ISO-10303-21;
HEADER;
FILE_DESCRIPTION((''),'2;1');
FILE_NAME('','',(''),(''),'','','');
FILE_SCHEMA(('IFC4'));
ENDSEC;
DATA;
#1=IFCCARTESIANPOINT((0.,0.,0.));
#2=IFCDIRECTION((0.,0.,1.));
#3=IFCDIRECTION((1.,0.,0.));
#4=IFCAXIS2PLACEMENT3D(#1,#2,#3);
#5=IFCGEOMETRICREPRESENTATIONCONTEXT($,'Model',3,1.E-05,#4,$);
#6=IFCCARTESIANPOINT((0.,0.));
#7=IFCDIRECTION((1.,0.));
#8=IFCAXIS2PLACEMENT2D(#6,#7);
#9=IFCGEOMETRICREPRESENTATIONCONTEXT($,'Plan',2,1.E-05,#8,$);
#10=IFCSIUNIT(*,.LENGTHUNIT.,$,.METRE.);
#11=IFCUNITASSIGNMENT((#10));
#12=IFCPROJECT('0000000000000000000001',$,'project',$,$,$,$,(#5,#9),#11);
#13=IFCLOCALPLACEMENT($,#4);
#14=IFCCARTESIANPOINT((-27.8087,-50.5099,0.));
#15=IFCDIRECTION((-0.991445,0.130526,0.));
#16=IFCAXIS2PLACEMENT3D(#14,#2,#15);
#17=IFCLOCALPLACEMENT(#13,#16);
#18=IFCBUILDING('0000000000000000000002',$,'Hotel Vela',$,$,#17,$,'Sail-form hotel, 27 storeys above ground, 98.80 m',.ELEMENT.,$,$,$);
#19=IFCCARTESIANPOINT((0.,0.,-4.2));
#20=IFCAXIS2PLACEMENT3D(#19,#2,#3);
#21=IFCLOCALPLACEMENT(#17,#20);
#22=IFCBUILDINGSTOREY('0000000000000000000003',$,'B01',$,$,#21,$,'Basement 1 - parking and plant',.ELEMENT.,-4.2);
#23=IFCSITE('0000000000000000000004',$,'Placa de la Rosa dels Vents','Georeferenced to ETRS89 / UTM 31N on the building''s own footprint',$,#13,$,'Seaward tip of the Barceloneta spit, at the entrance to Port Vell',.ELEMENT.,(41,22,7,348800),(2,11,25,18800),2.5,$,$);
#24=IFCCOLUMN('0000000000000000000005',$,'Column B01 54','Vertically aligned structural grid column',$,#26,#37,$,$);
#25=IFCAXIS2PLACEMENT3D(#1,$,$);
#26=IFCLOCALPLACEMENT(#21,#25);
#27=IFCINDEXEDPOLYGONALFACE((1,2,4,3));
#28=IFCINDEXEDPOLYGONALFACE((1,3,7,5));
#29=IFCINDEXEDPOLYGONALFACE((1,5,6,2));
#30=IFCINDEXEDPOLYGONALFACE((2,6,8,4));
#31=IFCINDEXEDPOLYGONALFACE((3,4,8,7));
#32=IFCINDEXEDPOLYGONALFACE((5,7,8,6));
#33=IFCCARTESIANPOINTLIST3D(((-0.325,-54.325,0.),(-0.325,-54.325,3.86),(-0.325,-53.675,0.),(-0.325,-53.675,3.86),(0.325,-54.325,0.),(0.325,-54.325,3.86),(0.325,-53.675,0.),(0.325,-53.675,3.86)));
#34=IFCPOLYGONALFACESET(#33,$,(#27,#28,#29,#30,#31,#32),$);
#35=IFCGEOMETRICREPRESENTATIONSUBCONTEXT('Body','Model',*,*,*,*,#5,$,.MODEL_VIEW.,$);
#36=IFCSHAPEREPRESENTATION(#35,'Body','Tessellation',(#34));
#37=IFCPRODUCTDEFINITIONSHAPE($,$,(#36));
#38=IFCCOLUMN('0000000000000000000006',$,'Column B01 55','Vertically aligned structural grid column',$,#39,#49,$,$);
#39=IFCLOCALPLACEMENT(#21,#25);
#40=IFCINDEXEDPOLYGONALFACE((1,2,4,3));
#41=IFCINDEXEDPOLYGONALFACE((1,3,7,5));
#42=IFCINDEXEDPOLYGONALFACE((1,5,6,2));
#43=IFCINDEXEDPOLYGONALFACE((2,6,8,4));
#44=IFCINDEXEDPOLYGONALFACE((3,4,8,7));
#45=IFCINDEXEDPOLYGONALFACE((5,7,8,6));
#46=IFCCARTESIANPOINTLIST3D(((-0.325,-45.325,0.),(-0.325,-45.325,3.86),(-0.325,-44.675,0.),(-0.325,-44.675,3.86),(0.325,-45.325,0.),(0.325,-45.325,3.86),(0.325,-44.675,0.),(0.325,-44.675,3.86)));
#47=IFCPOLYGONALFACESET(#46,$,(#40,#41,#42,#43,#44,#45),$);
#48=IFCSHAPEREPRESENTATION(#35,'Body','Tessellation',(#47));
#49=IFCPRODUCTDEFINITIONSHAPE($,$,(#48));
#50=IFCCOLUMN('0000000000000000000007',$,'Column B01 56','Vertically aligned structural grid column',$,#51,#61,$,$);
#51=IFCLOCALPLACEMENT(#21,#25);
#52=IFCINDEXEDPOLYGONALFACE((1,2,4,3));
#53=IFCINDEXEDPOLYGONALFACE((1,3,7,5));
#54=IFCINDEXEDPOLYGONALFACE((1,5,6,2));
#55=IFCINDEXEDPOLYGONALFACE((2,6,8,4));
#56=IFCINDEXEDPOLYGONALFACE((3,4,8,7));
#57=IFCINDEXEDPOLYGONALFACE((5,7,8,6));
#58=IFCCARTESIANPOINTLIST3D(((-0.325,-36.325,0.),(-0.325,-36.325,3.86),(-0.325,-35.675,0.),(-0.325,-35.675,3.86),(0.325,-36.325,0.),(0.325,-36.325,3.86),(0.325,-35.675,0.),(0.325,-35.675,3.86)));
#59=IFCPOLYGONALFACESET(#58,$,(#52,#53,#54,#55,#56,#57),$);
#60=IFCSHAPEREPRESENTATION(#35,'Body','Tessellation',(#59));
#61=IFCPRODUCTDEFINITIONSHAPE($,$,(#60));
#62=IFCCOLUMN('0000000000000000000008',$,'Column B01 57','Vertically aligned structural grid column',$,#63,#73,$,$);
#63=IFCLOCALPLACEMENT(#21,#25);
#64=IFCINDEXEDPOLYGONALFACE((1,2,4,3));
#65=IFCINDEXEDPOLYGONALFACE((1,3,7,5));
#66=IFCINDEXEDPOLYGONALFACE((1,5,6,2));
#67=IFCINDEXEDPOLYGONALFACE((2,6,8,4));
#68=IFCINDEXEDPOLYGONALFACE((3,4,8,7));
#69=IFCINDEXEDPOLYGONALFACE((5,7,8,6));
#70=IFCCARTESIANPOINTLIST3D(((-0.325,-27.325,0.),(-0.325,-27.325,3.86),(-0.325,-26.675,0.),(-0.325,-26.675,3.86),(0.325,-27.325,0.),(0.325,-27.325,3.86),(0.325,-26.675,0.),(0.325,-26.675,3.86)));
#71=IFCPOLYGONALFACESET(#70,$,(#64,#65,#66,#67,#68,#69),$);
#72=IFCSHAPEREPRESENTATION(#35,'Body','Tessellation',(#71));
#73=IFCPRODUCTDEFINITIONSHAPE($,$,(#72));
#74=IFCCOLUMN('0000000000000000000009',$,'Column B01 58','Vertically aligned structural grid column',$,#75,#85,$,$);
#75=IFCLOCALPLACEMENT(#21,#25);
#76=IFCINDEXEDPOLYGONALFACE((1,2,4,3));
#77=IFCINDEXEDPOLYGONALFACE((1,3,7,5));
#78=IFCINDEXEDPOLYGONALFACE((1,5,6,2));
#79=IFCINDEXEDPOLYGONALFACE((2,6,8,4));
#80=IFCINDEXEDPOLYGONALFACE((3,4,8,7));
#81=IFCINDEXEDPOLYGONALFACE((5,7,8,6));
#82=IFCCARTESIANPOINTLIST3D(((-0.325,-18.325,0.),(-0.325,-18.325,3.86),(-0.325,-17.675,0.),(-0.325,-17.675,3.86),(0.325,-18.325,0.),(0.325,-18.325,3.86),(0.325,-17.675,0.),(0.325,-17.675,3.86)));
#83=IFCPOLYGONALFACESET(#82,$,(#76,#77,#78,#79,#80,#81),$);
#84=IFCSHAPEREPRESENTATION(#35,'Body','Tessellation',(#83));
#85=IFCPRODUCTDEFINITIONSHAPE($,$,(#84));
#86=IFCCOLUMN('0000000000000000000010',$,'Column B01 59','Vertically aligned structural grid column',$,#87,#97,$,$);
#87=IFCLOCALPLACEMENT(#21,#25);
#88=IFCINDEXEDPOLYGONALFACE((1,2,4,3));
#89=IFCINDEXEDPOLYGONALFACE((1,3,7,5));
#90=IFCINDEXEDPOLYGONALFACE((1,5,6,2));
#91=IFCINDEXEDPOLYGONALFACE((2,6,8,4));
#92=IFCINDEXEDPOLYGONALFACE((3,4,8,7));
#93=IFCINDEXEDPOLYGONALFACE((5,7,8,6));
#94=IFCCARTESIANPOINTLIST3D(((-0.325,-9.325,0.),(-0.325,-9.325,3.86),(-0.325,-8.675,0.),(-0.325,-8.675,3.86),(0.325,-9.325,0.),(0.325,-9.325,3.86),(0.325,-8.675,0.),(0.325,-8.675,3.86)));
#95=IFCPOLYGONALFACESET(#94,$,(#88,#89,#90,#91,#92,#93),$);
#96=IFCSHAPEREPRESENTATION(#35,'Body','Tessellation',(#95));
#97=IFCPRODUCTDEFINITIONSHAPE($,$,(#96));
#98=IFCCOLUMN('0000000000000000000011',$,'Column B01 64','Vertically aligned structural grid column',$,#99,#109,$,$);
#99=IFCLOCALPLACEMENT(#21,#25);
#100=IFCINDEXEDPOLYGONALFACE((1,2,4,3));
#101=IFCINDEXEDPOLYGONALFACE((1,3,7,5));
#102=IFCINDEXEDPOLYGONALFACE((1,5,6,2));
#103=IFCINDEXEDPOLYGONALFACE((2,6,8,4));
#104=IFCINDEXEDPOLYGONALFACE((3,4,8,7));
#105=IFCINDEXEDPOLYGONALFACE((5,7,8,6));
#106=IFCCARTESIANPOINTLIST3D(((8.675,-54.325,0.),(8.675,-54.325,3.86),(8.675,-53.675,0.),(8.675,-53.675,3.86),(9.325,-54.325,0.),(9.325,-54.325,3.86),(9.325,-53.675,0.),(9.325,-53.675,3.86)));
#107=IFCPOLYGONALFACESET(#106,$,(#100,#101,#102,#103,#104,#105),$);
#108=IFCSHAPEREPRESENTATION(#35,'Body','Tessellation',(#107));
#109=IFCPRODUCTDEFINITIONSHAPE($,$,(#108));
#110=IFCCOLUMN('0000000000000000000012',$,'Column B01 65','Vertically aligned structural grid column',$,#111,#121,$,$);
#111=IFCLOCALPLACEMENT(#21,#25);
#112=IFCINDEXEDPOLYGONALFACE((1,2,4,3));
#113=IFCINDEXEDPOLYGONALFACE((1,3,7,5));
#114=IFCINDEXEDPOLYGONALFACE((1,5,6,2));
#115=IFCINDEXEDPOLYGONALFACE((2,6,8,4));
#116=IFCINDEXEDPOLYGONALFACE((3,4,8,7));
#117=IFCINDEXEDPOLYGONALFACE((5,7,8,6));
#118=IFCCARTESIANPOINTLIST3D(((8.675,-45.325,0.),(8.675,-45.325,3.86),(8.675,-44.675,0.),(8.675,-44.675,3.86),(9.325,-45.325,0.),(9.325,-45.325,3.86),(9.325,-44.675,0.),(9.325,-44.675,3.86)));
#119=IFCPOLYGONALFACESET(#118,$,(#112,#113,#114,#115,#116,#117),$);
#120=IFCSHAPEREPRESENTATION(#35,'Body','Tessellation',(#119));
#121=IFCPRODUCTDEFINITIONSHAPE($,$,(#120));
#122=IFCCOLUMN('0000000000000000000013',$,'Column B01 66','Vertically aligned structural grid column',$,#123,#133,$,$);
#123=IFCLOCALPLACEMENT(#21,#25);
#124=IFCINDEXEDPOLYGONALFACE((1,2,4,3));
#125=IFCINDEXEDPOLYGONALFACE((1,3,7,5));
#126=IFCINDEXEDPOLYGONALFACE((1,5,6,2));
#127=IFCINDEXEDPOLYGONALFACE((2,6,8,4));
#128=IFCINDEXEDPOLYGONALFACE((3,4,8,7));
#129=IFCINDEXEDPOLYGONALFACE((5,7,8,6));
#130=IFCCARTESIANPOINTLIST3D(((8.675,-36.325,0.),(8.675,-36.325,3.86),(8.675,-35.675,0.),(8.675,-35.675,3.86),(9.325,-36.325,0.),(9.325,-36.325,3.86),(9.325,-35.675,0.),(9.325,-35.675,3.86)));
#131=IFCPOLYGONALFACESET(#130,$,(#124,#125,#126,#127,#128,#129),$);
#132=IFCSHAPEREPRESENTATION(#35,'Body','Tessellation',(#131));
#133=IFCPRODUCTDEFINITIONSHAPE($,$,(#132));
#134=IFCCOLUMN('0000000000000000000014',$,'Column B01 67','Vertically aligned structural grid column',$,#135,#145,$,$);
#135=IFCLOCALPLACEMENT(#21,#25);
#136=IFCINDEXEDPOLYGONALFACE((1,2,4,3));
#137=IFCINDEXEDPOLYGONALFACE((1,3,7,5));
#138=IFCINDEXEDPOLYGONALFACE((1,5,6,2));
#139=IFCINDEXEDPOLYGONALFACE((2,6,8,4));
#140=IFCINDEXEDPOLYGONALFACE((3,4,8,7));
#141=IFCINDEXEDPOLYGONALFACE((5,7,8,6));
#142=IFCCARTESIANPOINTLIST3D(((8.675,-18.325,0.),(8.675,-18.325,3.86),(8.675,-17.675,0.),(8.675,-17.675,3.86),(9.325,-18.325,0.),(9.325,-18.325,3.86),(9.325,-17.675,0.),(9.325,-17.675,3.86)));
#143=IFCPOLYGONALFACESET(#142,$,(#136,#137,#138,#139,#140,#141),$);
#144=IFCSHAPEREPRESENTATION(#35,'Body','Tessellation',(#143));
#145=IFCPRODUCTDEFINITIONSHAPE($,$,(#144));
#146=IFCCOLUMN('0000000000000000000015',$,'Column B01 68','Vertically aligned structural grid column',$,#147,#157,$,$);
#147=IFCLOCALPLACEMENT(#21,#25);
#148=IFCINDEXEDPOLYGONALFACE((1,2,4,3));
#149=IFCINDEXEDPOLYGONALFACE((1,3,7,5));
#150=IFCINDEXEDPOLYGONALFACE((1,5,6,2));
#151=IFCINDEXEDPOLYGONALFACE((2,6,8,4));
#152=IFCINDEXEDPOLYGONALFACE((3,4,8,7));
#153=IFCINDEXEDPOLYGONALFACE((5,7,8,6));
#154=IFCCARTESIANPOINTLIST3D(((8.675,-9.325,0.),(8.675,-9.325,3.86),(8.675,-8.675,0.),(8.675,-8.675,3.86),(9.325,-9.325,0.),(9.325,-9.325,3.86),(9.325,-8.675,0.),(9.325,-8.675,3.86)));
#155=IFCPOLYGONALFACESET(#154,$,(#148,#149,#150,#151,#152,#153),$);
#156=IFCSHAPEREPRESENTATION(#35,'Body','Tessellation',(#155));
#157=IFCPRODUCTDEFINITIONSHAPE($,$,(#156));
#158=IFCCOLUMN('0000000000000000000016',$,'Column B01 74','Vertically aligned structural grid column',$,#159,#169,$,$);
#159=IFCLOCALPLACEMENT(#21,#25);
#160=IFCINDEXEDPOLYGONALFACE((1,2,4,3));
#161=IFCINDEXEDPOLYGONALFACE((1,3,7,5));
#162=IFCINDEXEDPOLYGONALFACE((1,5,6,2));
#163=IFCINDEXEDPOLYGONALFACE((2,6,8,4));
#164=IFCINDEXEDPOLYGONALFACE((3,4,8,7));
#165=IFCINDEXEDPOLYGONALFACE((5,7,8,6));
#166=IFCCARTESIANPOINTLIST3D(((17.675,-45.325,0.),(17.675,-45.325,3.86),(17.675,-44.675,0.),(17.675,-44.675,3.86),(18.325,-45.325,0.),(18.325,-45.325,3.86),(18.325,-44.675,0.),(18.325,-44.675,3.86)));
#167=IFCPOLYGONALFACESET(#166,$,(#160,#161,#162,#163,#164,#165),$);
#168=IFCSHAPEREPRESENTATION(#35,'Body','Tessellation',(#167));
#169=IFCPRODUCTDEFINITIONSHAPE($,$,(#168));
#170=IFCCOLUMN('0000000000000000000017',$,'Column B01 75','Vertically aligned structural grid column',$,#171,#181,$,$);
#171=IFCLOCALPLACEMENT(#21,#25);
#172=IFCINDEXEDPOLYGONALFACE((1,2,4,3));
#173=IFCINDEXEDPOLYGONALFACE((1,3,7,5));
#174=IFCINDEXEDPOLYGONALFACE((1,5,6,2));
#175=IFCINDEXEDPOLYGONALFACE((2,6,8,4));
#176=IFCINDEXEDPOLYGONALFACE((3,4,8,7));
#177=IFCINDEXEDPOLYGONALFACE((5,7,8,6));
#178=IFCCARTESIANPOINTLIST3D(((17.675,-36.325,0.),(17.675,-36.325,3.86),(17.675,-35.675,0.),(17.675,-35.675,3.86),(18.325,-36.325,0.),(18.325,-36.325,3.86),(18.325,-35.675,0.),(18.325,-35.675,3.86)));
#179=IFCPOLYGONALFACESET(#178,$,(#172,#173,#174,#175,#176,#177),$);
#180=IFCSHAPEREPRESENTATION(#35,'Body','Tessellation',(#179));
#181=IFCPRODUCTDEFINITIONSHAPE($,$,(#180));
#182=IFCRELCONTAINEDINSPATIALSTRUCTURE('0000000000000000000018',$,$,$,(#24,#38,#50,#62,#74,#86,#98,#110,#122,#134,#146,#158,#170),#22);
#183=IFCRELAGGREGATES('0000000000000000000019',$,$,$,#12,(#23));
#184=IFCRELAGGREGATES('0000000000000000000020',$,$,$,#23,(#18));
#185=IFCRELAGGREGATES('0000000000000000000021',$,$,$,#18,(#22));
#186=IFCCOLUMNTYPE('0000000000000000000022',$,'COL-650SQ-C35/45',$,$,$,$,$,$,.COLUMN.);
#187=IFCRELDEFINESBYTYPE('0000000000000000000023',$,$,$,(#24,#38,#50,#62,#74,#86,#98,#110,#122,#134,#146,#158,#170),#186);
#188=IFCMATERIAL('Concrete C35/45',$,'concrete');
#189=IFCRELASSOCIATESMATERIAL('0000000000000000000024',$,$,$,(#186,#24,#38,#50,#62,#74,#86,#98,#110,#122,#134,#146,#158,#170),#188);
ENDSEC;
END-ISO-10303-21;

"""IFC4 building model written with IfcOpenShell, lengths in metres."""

from ifc_helpers import new_model, si_unit, frame, origin_with_axes, origin_2d_with_axis, place, context, subcontext, project, spatial, line, indexed_curve, rectangle, outline, extrude, material, material_profile, profile_set, profile_usage, type_object, element, save


model = new_model("IFC4")

# Units and contexts
model_context = context("Model", 3, precision=1e-05, world=origin_with_axes())
plan_context = context("Plan", 2, precision=1e-05, world=origin_2d_with_axis())
body_context = subcontext(model_context, "Body", "Model", "MODEL_VIEW")
ifc_project = project(units=[si_unit("LENGTHUNIT", "METRE")], contexts=[model_context, plan_context])

# Site, building, storey
site_placement = place(None, origin_with_axes())
site = spatial("IfcSite", under=ifc_project, at=site_placement, Name="Placa de la Rosa dels Vents", Description="Georeferenced to ETRS89 / UTM 31N on the building's own footprint", LongName="Seaward tip of the Barceloneta spit, at the entrance to Port Vell", CompositionType="ELEMENT", RefLatitude=(41, 22, 7, 348800), RefLongitude=(2, 11, 25, 18800), RefElevation=2.5)
building_placement = place(site_placement, frame((-27.8087, -50.5099, 0.0), z_axis=(0.0, 0.0, 1.0), x_axis=(-0.991445, 0.130526, 0.0)))
building = spatial("IfcBuilding", under=site, at=building_placement, Name="Hotel Vela", LongName="Sail-form hotel, 27 storeys above ground, 98.80 m", CompositionType="ELEMENT")
storey_placement = place(building_placement, frame((0.0, 0.0, -4.2), z_axis=(0.0, 0.0, 1.0), x_axis=(1.0, 0.0, 0.0)))
storey = spatial("IfcBuildingStorey", under=building, at=storey_placement, Name="B01", LongName="Basement 1 - parking and plant", CompositionType="ELEMENT", Elevation=-4.2)

# Columns
ifc_material = material(Name="Concrete C35/45", Category="concrete")
ifc_material_profile = material_profile(ifc_material, rectangle(XDim=0.65, YDim=0.65))
ifc_profile_set = profile_set([ifc_material_profile], Name="COL-650SQ-C35/45")
ifc_profile_usage_1 = profile_usage(ifc_profile_set)
column_type = type_object("IfcColumnType", Name="COL-650SQ-C35/45", PredefinedType="COLUMN", material=ifc_profile_set)
column_1_placement = place(storey_placement, frame((-0.325, -54.325, 0.0), z_axis=(0.0, 0.0, 1.0), x_axis=(1.0, 0.0, 0.0)))
element("IfcColumn", 1, at=column_1_placement, inside=storey, type_object=column_type, material=ifc_profile_usage_1, Name="Column B01 54", Description="Vertically aligned structural grid column", context=body_context, shape_type="SweptSolid", body=[
    extrude(outline(indexed_curve([(0.0, 0.0), (0.65, 0.0), (0.65, 0.65), (0.0, 0.65)], segments=[line(1, 2, 3, 4, 1)])), origin_with_axes(), (0.0, 0.0, 1.0), 3.86),
])
ifc_profile_usage_2 = profile_usage(ifc_profile_set)
column_2_placement = place(storey_placement, frame((-0.325, -45.325, 0.0), z_axis=(0.0, 0.0, 1.0), x_axis=(1.0, 0.0, 0.0)))
element("IfcColumn", 2, at=column_2_placement, inside=storey, type_object=column_type, material=ifc_profile_usage_2, Name="Column B01 55", Description="Vertically aligned structural grid column", context=body_context, shape_type="SweptSolid", body=[
    extrude(outline(indexed_curve([(0.0, 0.0), (0.65, 0.0), (0.65, 0.65), (0.0, 0.65)], segments=[line(1, 2, 3, 4, 1)])), origin_with_axes(), (0.0, 0.0, 1.0), 3.86),
])
ifc_profile_usage_3 = profile_usage(ifc_profile_set)
column_3_placement = place(storey_placement, frame((-0.325, -36.325, 0.0), z_axis=(0.0, 0.0, 1.0), x_axis=(1.0, 0.0, 0.0)))
element("IfcColumn", 3, at=column_3_placement, inside=storey, type_object=column_type, material=ifc_profile_usage_3, Name="Column B01 56", Description="Vertically aligned structural grid column", context=body_context, shape_type="SweptSolid", body=[
    extrude(outline(indexed_curve([(0.0, 0.0), (0.65, 0.0), (0.65, 0.65), (0.0, 0.65)], segments=[line(1, 2, 3, 4, 1)])), origin_with_axes(), (0.0, 0.0, 1.0), 3.86),
])
ifc_profile_usage_4 = profile_usage(ifc_profile_set)
column_4_placement = place(storey_placement, frame((-0.325, -27.325, 0.0), z_axis=(0.0, 0.0, 1.0), x_axis=(1.0, 0.0, 0.0)))
element("IfcColumn", 4, at=column_4_placement, inside=storey, type_object=column_type, material=ifc_profile_usage_4, Name="Column B01 57", Description="Vertically aligned structural grid column", context=body_context, shape_type="SweptSolid", body=[
    extrude(outline(indexed_curve([(0.0, 0.0), (0.65, 0.0), (0.65, 0.65), (0.0, 0.65)], segments=[line(1, 2, 3, 4, 1)])), origin_with_axes(), (0.0, 0.0, 1.0), 3.86),
])
ifc_profile_usage_5 = profile_usage(ifc_profile_set)
column_5_placement = place(storey_placement, frame((-0.325, -18.325, 0.0), z_axis=(0.0, 0.0, 1.0), x_axis=(1.0, 0.0, 0.0)))
element("IfcColumn", 5, at=column_5_placement, inside=storey, type_object=column_type, material=ifc_profile_usage_5, Name="Column B01 58", Description="Vertically aligned structural grid column", context=body_context, shape_type="SweptSolid", body=[
    extrude(outline(indexed_curve([(0.0, 0.0), (0.65, 0.0), (0.65, 0.65), (0.0, 0.65)], segments=[line(1, 2, 3, 4, 1)])), origin_with_axes(), (0.0, 0.0, 1.0), 3.86),
])
ifc_profile_usage_6 = profile_usage(ifc_profile_set)
column_6_placement = place(storey_placement, frame((-0.325, -9.325, 0.0), z_axis=(0.0, 0.0, 1.0), x_axis=(1.0, 0.0, 0.0)))
element("IfcColumn", 6, at=column_6_placement, inside=storey, type_object=column_type, material=ifc_profile_usage_6, Name="Column B01 59", Description="Vertically aligned structural grid column", context=body_context, shape_type="SweptSolid", body=[
    extrude(outline(indexed_curve([(0.0, 0.0), (0.65, 0.0), (0.65, 0.65), (0.0, 0.65)], segments=[line(1, 2, 3, 4, 1)])), origin_with_axes(), (0.0, 0.0, 1.0), 3.86),
])
ifc_profile_usage_7 = profile_usage(ifc_profile_set)
column_7_placement = place(storey_placement, frame((8.675, -54.325, 0.0), z_axis=(0.0, 0.0, 1.0), x_axis=(1.0, 0.0, 0.0)))
element("IfcColumn", 7, at=column_7_placement, inside=storey, type_object=column_type, material=ifc_profile_usage_7, Name="Column B01 64", Description="Vertically aligned structural grid column", context=body_context, shape_type="SweptSolid", body=[
    extrude(outline(indexed_curve([(0.0, 0.0), (0.65, 0.0), (0.65, 0.65), (0.0, 0.65)], segments=[line(1, 2, 3, 4, 1)])), origin_with_axes(), (0.0, 0.0, 1.0), 3.86),
])
ifc_profile_usage_8 = profile_usage(ifc_profile_set)
column_8_placement = place(storey_placement, frame((8.675, -45.325, 0.0), z_axis=(0.0, 0.0, 1.0), x_axis=(1.0, 0.0, 0.0)))
element("IfcColumn", 8, at=column_8_placement, inside=storey, type_object=column_type, material=ifc_profile_usage_8, Name="Column B01 65", Description="Vertically aligned structural grid column", context=body_context, shape_type="SweptSolid", body=[
    extrude(outline(indexed_curve([(0.0, 0.0), (0.65, 0.0), (0.65, 0.65), (0.0, 0.65)], segments=[line(1, 2, 3, 4, 1)])), origin_with_axes(), (0.0, 0.0, 1.0), 3.86),
])
ifc_profile_usage_9 = profile_usage(ifc_profile_set)
column_9_placement = place(storey_placement, frame((8.675, -36.325, 0.0), z_axis=(0.0, 0.0, 1.0), x_axis=(1.0, 0.0, 0.0)))
element("IfcColumn", 9, at=column_9_placement, inside=storey, type_object=column_type, material=ifc_profile_usage_9, Name="Column B01 66", Description="Vertically aligned structural grid column", context=body_context, shape_type="SweptSolid", body=[
    extrude(outline(indexed_curve([(0.0, 0.0), (0.65, 0.0), (0.65, 0.65), (0.0, 0.65)], segments=[line(1, 2, 3, 4, 1)])), origin_with_axes(), (0.0, 0.0, 1.0), 3.86),
])
ifc_profile_usage_10 = profile_usage(ifc_profile_set)
column_10_placement = place(storey_placement, frame((8.675, -18.325, 0.0), z_axis=(0.0, 0.0, 1.0), x_axis=(1.0, 0.0, 0.0)))
element("IfcColumn", 10, at=column_10_placement, inside=storey, type_object=column_type, material=ifc_profile_usage_10, Name="Column B01 67", Description="Vertically aligned structural grid column", context=body_context, shape_type="SweptSolid", body=[
    extrude(outline(indexed_curve([(0.0, 0.0), (0.65, 0.0), (0.65, 0.65), (0.0, 0.65)], segments=[line(1, 2, 3, 4, 1)])), origin_with_axes(), (0.0, 0.0, 1.0), 3.86),
])
ifc_profile_usage_11 = profile_usage(ifc_profile_set)
column_11_placement = place(storey_placement, frame((8.675, -9.325, 0.0), z_axis=(0.0, 0.0, 1.0), x_axis=(1.0, 0.0, 0.0)))
element("IfcColumn", 11, at=column_11_placement, inside=storey, type_object=column_type, material=ifc_profile_usage_11, Name="Column B01 68", Description="Vertically aligned structural grid column", context=body_context, shape_type="SweptSolid", body=[
    extrude(outline(indexed_curve([(0.0, 0.0), (0.65, 0.0), (0.65, 0.65), (0.0, 0.65)], segments=[line(1, 2, 3, 4, 1)])), origin_with_axes(), (0.0, 0.0, 1.0), 3.86),
])
ifc_profile_usage_12 = profile_usage(ifc_profile_set)
column_12_placement = place(storey_placement, frame((17.675, -45.325, 0.0), z_axis=(0.0, 0.0, 1.0), x_axis=(1.0, 0.0, 0.0)))
element("IfcColumn", 12, at=column_12_placement, inside=storey, type_object=column_type, material=ifc_profile_usage_12, Name="Column B01 74", Description="Vertically aligned structural grid column", context=body_context, shape_type="SweptSolid", body=[
    extrude(outline(indexed_curve([(0.0, 0.0), (0.65, 0.0), (0.65, 0.65), (0.0, 0.65)], segments=[line(1, 2, 3, 4, 1)])), origin_with_axes(), (0.0, 0.0, 1.0), 3.86),
])
ifc_profile_usage_13 = profile_usage(ifc_profile_set)
column_13_placement = place(storey_placement, frame((17.675, -36.325, 0.0), z_axis=(0.0, 0.0, 1.0), x_axis=(1.0, 0.0, 0.0)))
element("IfcColumn", 13, at=column_13_placement, inside=storey, type_object=column_type, material=ifc_profile_usage_13, Name="Column B01 75", Description="Vertically aligned structural grid column", context=body_context, shape_type="SweptSolid", body=[
    extrude(outline(indexed_curve([(0.0, 0.0), (0.65, 0.0), (0.65, 0.65), (0.0, 0.65)], segments=[line(1, 2, 3, 4, 1)])), origin_with_axes(), (0.0, 0.0, 1.0), 3.86),
])

save(model, "model.ifc")
